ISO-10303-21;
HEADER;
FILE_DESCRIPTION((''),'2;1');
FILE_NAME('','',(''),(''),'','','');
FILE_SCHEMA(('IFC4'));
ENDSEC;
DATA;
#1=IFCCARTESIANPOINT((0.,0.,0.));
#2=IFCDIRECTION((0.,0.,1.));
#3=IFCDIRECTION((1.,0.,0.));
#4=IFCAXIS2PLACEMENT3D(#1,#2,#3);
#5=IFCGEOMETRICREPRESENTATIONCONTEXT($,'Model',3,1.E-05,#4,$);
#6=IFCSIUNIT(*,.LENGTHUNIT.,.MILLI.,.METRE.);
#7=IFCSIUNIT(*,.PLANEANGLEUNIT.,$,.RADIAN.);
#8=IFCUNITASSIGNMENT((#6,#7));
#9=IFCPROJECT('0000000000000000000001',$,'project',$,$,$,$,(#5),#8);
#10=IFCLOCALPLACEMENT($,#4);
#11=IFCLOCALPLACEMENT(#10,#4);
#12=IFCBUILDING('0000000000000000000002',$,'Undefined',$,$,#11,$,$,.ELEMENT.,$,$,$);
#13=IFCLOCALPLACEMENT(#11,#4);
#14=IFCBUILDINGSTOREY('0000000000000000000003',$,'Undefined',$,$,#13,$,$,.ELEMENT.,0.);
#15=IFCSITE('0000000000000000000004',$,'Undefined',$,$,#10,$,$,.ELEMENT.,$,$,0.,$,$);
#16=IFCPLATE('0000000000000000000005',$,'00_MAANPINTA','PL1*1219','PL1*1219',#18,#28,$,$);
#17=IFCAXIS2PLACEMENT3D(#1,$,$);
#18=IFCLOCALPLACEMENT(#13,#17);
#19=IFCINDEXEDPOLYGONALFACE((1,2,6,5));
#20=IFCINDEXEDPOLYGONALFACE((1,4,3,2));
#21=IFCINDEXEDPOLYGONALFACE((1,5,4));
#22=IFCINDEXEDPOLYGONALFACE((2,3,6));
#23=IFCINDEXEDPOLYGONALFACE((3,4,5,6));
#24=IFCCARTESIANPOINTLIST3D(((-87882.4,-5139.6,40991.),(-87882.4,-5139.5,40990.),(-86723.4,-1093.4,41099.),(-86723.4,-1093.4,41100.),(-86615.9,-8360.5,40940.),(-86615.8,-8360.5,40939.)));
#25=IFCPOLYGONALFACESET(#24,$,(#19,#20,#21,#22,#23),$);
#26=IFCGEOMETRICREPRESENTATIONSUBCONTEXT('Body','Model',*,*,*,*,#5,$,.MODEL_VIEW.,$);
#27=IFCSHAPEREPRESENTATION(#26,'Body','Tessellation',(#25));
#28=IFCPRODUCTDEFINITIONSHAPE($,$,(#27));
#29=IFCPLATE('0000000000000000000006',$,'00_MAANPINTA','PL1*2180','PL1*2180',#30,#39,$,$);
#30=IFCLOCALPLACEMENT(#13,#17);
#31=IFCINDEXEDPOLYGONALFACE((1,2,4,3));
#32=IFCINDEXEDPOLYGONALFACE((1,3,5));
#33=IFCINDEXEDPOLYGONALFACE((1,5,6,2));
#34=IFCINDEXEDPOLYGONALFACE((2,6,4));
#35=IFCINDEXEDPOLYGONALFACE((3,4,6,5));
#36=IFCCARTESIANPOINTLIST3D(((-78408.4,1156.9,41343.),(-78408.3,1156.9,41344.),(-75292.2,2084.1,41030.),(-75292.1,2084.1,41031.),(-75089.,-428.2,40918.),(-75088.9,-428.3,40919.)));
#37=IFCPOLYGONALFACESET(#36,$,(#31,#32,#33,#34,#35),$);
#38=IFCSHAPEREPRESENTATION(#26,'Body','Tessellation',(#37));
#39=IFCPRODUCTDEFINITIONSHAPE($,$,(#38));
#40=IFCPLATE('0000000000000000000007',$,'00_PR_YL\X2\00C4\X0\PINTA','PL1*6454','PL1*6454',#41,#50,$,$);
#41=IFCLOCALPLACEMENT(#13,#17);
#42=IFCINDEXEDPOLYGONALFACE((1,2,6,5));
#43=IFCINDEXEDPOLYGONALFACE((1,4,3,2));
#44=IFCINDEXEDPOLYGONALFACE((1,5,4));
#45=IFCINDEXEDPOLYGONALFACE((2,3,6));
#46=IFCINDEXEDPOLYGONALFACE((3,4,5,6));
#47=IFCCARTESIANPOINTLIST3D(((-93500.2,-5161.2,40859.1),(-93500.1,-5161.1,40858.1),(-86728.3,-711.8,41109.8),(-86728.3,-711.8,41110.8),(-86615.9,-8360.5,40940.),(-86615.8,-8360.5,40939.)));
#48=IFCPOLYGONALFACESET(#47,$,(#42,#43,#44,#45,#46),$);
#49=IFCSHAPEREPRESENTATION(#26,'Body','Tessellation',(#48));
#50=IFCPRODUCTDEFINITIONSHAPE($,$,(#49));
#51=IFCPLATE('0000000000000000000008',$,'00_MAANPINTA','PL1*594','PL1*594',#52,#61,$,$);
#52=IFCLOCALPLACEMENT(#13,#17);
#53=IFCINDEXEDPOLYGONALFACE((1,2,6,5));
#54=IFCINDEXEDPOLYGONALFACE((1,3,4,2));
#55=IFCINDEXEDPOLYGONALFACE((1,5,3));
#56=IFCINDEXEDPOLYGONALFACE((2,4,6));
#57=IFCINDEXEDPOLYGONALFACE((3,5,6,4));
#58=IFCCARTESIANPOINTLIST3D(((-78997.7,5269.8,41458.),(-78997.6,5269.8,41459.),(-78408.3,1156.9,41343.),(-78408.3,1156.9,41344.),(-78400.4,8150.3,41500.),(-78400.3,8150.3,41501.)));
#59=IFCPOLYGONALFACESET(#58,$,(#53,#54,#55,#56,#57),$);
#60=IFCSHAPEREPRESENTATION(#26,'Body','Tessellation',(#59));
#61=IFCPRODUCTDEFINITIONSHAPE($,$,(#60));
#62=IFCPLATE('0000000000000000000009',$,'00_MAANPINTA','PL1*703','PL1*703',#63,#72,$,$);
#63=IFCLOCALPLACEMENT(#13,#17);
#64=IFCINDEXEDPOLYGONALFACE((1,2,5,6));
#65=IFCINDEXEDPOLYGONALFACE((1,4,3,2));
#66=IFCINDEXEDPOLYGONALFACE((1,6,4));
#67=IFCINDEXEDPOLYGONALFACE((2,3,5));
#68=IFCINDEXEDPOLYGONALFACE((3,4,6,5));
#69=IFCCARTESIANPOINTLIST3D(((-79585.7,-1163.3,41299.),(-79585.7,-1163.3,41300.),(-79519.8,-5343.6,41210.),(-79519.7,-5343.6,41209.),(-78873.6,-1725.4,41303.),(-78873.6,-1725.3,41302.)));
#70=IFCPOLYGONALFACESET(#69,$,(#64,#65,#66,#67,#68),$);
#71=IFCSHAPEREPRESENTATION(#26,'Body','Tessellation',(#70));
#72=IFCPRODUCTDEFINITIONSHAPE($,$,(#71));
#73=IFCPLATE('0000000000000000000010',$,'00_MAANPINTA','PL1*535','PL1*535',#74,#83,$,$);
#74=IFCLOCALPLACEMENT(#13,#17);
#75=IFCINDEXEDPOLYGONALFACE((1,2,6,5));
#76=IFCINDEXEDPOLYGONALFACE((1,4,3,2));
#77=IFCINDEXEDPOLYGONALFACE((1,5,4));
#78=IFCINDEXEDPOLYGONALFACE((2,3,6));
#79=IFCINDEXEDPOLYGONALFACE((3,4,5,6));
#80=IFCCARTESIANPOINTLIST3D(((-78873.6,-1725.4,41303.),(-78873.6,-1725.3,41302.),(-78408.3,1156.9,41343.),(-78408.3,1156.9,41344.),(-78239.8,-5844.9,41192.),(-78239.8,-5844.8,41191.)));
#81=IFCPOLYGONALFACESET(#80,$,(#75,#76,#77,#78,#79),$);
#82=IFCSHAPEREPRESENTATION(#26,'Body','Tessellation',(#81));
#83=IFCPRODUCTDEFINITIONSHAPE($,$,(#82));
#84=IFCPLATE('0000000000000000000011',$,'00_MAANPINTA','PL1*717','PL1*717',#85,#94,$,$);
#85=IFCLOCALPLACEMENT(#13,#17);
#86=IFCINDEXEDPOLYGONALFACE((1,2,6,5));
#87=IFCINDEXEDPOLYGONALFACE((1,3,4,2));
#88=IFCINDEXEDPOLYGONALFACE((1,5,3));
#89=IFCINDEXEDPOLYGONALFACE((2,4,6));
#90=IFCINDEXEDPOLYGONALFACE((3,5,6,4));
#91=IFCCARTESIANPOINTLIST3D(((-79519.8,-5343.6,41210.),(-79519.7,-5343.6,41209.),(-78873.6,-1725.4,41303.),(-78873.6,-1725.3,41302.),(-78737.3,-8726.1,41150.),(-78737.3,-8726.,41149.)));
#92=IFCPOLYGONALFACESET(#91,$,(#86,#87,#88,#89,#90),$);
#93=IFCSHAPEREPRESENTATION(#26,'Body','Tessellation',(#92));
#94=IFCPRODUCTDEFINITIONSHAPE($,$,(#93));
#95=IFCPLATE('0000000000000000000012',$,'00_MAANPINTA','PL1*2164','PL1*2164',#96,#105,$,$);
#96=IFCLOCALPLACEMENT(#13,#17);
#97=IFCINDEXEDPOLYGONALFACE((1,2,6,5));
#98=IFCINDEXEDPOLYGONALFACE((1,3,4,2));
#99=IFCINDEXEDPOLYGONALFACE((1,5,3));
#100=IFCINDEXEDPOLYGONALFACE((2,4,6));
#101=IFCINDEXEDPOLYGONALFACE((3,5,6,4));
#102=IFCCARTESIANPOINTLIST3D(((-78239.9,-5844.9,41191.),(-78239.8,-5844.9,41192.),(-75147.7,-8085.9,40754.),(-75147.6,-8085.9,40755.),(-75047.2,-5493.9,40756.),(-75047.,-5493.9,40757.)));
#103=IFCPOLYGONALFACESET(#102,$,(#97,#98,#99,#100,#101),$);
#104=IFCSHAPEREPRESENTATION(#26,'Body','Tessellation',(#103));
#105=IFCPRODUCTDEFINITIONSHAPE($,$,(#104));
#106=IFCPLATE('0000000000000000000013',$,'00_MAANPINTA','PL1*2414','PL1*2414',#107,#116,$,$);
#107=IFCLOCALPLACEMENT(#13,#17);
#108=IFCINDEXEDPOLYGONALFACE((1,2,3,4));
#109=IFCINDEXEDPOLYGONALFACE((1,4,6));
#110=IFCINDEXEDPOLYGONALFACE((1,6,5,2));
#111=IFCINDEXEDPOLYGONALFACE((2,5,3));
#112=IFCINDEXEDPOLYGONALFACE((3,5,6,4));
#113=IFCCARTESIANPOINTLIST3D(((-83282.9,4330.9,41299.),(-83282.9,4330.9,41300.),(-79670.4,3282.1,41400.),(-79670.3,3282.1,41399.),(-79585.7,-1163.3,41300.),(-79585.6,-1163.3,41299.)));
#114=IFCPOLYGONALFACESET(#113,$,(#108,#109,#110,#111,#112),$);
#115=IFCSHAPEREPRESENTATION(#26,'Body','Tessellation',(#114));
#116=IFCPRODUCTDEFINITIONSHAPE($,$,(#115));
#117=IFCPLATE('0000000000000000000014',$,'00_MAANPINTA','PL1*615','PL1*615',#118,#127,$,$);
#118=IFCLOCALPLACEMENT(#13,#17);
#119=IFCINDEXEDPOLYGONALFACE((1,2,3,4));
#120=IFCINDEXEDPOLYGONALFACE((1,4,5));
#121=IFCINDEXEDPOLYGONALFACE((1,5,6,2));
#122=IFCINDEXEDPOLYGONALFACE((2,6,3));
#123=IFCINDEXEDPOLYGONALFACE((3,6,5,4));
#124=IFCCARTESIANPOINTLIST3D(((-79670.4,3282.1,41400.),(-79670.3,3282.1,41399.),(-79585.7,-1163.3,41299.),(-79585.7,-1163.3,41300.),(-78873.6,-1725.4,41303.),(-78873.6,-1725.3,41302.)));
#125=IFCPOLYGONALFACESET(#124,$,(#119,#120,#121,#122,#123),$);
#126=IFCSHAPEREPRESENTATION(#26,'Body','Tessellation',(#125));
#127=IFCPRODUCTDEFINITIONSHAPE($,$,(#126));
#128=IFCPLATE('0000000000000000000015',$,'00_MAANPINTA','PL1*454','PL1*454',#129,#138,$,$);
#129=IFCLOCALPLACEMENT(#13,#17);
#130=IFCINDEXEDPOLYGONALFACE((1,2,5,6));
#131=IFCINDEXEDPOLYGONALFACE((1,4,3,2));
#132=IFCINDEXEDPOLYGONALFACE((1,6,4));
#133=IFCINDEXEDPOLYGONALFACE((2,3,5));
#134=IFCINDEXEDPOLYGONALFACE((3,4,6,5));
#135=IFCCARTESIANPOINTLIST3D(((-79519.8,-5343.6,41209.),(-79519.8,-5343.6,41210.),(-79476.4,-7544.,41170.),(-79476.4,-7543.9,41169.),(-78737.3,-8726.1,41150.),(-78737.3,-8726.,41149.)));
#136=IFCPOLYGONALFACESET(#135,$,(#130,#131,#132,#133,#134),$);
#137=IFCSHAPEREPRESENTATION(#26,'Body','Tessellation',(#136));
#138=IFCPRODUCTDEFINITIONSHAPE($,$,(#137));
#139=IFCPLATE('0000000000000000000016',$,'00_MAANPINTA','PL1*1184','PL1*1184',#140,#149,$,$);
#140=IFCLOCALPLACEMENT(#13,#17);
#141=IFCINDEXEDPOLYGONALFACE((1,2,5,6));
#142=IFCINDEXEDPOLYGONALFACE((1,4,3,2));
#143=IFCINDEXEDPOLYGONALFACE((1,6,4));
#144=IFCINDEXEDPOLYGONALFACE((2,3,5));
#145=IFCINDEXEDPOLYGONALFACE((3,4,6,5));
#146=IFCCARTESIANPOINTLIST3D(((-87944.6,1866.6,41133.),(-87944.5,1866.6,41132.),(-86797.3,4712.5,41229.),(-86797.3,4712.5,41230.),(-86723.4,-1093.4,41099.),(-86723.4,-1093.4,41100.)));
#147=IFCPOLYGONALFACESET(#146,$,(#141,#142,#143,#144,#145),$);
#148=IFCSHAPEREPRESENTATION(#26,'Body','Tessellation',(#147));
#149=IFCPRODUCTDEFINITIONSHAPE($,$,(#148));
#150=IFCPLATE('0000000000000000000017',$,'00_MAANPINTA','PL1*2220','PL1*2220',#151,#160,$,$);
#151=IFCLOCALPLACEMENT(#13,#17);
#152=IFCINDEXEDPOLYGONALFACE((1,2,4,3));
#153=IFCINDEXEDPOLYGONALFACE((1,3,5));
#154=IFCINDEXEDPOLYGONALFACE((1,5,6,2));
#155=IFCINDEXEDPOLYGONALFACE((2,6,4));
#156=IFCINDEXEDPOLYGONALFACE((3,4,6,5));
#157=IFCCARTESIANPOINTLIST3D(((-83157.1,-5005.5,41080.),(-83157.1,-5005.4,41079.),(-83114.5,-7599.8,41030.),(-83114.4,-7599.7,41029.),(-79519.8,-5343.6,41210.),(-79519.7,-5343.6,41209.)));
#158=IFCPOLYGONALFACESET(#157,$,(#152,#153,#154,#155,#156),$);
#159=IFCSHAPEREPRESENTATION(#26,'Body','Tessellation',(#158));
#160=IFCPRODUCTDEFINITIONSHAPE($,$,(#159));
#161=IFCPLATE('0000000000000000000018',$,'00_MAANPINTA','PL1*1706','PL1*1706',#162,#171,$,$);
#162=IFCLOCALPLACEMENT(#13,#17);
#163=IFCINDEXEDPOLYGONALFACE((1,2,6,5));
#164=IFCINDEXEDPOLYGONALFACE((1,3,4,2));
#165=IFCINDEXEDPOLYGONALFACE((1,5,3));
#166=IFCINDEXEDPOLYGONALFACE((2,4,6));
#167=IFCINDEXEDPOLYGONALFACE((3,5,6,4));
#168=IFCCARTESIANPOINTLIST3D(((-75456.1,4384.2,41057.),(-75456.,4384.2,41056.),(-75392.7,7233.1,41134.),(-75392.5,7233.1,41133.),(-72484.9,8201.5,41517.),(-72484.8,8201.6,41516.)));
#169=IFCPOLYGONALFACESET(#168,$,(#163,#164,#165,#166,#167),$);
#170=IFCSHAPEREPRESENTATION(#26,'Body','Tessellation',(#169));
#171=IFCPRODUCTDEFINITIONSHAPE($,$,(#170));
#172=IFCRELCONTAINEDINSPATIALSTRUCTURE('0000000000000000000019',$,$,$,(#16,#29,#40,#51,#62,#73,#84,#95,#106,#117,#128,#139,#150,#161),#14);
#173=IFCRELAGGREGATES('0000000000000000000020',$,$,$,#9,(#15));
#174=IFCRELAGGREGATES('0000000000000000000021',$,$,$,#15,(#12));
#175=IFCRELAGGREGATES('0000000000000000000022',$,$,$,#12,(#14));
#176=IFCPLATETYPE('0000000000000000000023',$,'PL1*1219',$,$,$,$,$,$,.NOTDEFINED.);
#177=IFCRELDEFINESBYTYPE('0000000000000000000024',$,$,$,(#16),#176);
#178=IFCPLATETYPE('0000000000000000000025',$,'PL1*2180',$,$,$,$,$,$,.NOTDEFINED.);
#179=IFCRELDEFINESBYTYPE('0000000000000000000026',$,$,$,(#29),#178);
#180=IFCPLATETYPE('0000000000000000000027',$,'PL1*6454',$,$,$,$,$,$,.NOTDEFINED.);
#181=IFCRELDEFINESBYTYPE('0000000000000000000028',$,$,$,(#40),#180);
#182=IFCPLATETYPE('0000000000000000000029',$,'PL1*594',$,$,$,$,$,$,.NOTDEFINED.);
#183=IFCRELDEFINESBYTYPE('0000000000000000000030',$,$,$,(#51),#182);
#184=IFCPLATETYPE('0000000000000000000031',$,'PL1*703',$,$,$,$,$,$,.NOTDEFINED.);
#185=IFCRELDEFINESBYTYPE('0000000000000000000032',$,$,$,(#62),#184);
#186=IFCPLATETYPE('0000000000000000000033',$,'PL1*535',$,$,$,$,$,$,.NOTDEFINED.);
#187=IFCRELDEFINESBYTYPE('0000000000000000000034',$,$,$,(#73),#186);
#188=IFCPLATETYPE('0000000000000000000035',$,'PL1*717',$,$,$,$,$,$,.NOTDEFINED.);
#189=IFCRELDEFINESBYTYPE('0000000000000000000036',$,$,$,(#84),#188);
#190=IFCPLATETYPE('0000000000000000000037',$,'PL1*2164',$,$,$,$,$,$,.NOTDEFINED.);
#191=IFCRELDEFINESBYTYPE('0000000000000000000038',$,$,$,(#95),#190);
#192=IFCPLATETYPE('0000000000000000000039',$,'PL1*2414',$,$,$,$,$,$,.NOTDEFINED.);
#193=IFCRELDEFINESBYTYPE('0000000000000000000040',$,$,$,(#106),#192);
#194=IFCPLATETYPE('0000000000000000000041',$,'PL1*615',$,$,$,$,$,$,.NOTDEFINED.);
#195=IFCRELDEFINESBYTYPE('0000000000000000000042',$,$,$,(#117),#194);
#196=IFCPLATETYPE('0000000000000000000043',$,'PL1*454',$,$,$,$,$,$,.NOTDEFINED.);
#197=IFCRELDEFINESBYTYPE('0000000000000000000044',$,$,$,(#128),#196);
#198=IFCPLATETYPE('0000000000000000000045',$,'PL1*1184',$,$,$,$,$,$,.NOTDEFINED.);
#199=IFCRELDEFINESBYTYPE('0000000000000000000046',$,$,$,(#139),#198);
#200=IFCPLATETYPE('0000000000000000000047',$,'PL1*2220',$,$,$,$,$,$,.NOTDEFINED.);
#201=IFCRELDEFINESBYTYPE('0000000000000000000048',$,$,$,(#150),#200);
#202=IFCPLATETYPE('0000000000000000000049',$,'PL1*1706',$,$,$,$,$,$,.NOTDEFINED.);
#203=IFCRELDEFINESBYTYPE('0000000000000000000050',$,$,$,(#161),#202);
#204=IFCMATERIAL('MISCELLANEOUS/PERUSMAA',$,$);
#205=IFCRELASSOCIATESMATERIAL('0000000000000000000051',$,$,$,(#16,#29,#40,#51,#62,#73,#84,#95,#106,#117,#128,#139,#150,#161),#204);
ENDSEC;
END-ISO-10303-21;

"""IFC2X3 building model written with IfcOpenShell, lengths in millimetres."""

from ifc_helpers import new_model, si_unit, frame, origin_with_axes, place, context, subcontext, project, spatial, polyline, outline, extrude, material, type_object, element, save


model = new_model("IFC2X3")

# Units and contexts
model_context = context("Model", 3, precision=1e-05, world=origin_with_axes())
body_context = subcontext(model_context, "Body", "Model", "MODEL_VIEW")
ifc_project = project(units=[si_unit("LENGTHUNIT", "METRE", prefix="MILLI"), si_unit("PLANEANGLEUNIT", "RADIAN")], contexts=[model_context])

# Site, building, storey
site_placement = place(None, origin_with_axes())
site = spatial("IfcSite", under=ifc_project, at=site_placement, Name="Undefined", CompositionType="ELEMENT", RefElevation=0.0)
building_placement = place(site_placement, origin_with_axes())
building = spatial("IfcBuilding", under=site, at=building_placement, Name="Undefined", CompositionType="ELEMENT")
storey_placement = place(building_placement, origin_with_axes())
storey = spatial("IfcBuildingStorey", under=building, at=storey_placement, Name="Undefined", CompositionType="ELEMENT", Elevation=0.0)

# Plates
ifc_material = material(Name="MISCELLANEOUS/PERUSMAA")
plate_type_1 = type_object("IfcPlateType", Name="PL1*1219", PredefinedType="NOTDEFINED")
plate_1_placement = place(storey_placement, frame((-86615.9, -8360.5, 40939.5), z_axis=(0.016334, 0.022251, -0.999619), x_axis=(-0.3659, 0.930537, 0.014734)))
element("IfcPlate", 1, at=plate_1_placement, inside=storey, type_object=plate_type_1, material=ifc_material, Name="00_MAANPINTA", Description="PL1*1219", ObjectType="PL1*1219", context=body_context, shape_type="SweptSolid", body=[
    extrude(outline(polyline([(0.0, 0.0), (3461.4, 0.0), (6804.0, 2559.9), (0.0, 0.0)])), frame((0.0, 0.0, -0.5), z_axis=(0.0, 0.0, 1.0), x_axis=(1.0, 0.0, 0.0)), (0.0, 0.0, 1.0), 1.0),
])
plate_type_2 = type_object("IfcPlateType", Name="PL1*2180", PredefinedType="NOTDEFINED")
plate_2_placement = place(storey_placement, frame((-78408.3, 1156.9, 41343.5), z_axis=(-0.110288, 0.035359, -0.993271), x_axis=(0.954062, 0.283871, -0.095829)))
element("IfcPlate", 2, at=plate_2_placement, inside=storey, type_object=plate_type_2, material=ifc_material, Name="00_MAANPINTA", Description="PL1*2180", ObjectType="PL1*2180", context=body_context, shape_type="SweptSolid", body=[
    extrude(outline(polyline([(0.0, 0.0), (3266.2, 0.0), (2757.7, 2471.3), (0.0, 0.0)])), frame((0.0, 0.0, -0.5), z_axis=(0.0, 0.0, 1.0), x_axis=(1.0, 0.0, 0.0)), (0.0, 0.0, 1.0), 1.0),
])
plate_type_3 = type_object("IfcPlateType", Name="PL1*6454", PredefinedType="NOTDEFINED")
plate_3_placement = place(storey_placement, frame((-86728.3, -711.8, 41110.3), z_axis=(0.022274, 0.022651, -0.999495), x_axis=(0.014694, -0.999643, -0.022327)))
element("IfcPlate", 3, at=plate_3_placement, inside=storey, type_object=plate_type_3, material=ifc_material, Name="00_PR_YLÄPINTA", Description="PL1*6454", ObjectType="PL1*6454", context=body_context, shape_type="SweptSolid", body=[
    extrude(outline(polyline([(0.0, 0.0), (7651.4, 0.0), (4353.9, 6838.3), (0.0, 0.0)])), frame((0.0, 0.0, -0.5), z_axis=(0.0, 0.0, 1.0), x_axis=(1.0, 0.0, 0.0)), (0.0, 0.0, 1.0), 1.0),
])
plate_type_4 = type_object("IfcPlateType", Name="PL1*594", PredefinedType="NOTDEFINED")
plate_4_placement = place(storey_placement, frame((-78408.3, 1156.9, 41343.5), z_axis=(-0.038119, 0.022471, -0.99902), x_axis=(-0.141791, 0.98951, 0.027667)))
element("IfcPlate", 4, at=plate_4_placement, inside=storey, type_object=plate_type_4, material=ifc_material, Name="00_MAANPINTA", Description="PL1*594", ObjectType="PL1*594", context=body_context, shape_type="SweptSolid", body=[
    extrude(outline(polyline([(0.0, 0.0), (4156.5, 0.0), (6923.3, 1000.4), (0.0, 0.0)])), frame((0.0, 0.0, -0.5), z_axis=(0.0, 0.0, 1.0), x_axis=(1.0, 0.0, 0.0)), (0.0, 0.0, 1.0), 1.0),
])
plate_type_5 = type_object("IfcPlateType", Name="PL1*703", PredefinedType="NOTDEFINED")
plate_5_placement = place(storey_placement, frame((-79519.8, -5343.6, 41209.5), z_axis=(0.021464, 0.021858, -0.999531), x_axis=(-0.015762, 0.999644, 0.021522)))
element("IfcPlate", 5, at=plate_5_placement, inside=storey, type_object=plate_type_5, material=ifc_material, Name="00_MAANPINTA", Description="PL1*703", ObjectType="PL1*703", context=body_context, shape_type="SweptSolid", body=[
    extrude(outline(polyline([(0.0, 0.0), (4181.8, 0.0), (3608.8, 703.3), (0.0, 0.0)])), frame((0.0, 0.0, -0.5), z_axis=(0.0, 0.0, 1.0), x_axis=(1.0, 0.0, 0.0)), (0.0, 0.0, 1.0), 1.0),
])
plate_type_6 = type_object("IfcPlateType", Name="PL1*535", PredefinedType="NOTDEFINED")
plate_6_placement = place(storey_placement, frame((-78239.8, -5844.9, 41191.5), z_axis=(-0.040302, 0.020717, -0.998973), x_axis=(-0.152014, 0.98802, 0.026622)))
element("IfcPlate", 6, at=plate_6_placement, inside=storey, type_object=plate_type_6, material=ifc_material, Name="00_MAANPINTA", Description="PL1*535", ObjectType="PL1*535", context=body_context, shape_type="SweptSolid", body=[
    extrude(outline(polyline([(0.0, 0.0), (4169.4, 0.0), (6947.5, 898.8), (0.0, 0.0)])), frame((0.0, 0.0, -0.5), z_axis=(0.0, 0.0, 1.0), x_axis=(1.0, 0.0, 0.0)), (0.0, 0.0, 1.0), 1.0),
])
plate_type_7 = type_object("IfcPlateType", Name="PL1*717", PredefinedType="NOTDEFINED")
plate_7_placement = place(storey_placement, frame((-78873.6, -1725.4, 41302.5), z_axis=(0.019421, 0.022224, -0.999564), x_axis=(0.019465, -0.999572, -0.021846)))
element("IfcPlate", 7, at=plate_7_placement, inside=storey, type_object=plate_type_7, material=ifc_material, Name="00_MAANPINTA", Description="PL1*717", ObjectType="PL1*717", context=body_context, shape_type="SweptSolid", body=[
    extrude(outline(polyline([(0.0, 0.0), (7003.7, 0.0), (3606.1, 716.6), (0.0, 0.0)])), frame((0.0, 0.0, -0.5), z_axis=(0.0, 0.0, 1.0), x_axis=(1.0, 0.0, 0.0)), (0.0, 0.0, 1.0), 1.0),
])
plate_type_8 = type_object("IfcPlateType", Name="PL1*2164", PredefinedType="NOTDEFINED")
plate_8_placement = place(storey_placement, frame((-78239.9, -5844.9, 41191.5), z_axis=(-0.135647, 0.006026, -0.990739), x_axis=(0.985021, 0.108269, -0.134206)))
element("IfcPlate", 8, at=plate_8_placement, inside=storey, type_object=plate_type_8, material=ifc_material, Name="00_MAANPINTA", Description="PL1*2164", ObjectType="PL1*2164", context=body_context, shape_type="SweptSolid", body=[
    extrude(outline(polyline([(0.0, 0.0), (3241.3, 0.0), (2861.9, 2566.0), (0.0, 0.0)])), frame((0.0, 0.0, -0.5), z_axis=(0.0, 0.0, 1.0), x_axis=(1.0, 0.0, 0.0)), (0.0, 0.0, 1.0), 1.0),
])
plate_type_9 = type_object("IfcPlateType", Name="PL1*2414", PredefinedType="NOTDEFINED")
plate_9_placement = place(storey_placement, frame((-83282.9, 4330.9, 41299.5), z_axis=(0.034373, 0.023131, -0.999141), x_axis=(0.960005, -0.278718, 0.026574)))
element("IfcPlate", 9, at=plate_9_placement, inside=storey, type_object=plate_type_9, material=ifc_material, Name="00_MAANPINTA", Description="PL1*2414", ObjectType="PL1*2414", context=body_context, shape_type="SweptSolid", body=[
    extrude(outline(polyline([(0.0, 0.0), (3763.1, 0.0), (5080.7, 4247.6), (0.0, 0.0)])), frame((0.0, 0.0, -0.5), z_axis=(0.0, 0.0, 1.0), x_axis=(1.0, 0.0, 0.0)), (0.0, 0.0, 1.0), 1.0),
])
plate_type_10 = type_object("IfcPlateType", Name="PL1*615", PredefinedType="NOTDEFINED")
plate_10_placement = place(storey_placement, frame((-79670.3, 3282.1, 41399.5), z_axis=(0.022294, 0.022909, -0.999489), x_axis=(0.15711, -0.987396, -0.019127)))
element("IfcPlate", 10, at=plate_10_placement, inside=storey, type_object=plate_type_10, material=ifc_material, Name="00_MAANPINTA", Description="PL1*615", ObjectType="PL1*615", context=body_context, shape_type="SweptSolid", body=[
    extrude(outline(polyline([(0.0, 0.0), (5071.4, 0.0), (4404.5, 615.1), (0.0, 0.0)])), frame((0.0, 0.0, -0.5), z_axis=(0.0, 0.0, 1.0), x_axis=(1.0, 0.0, 0.0)), (0.0, 0.0, 1.0), 1.0),
])
plate_type_11 = type_object("IfcPlateType", Name="PL1*454", PredefinedType="NOTDEFINED")
plate_11_placement = place(storey_placement, frame((-79519.8, -5343.6, 41209.5), z_axis=(0.00208, 0.018217, -0.999832), x_axis=(0.225352, -0.974124, -0.01728)))
element("IfcPlate", 11, at=plate_11_placement, inside=storey, type_object=plate_type_11, material=ifc_material, Name="00_MAANPINTA", Description="PL1*454", ObjectType="PL1*454", context=body_context, shape_type="SweptSolid", body=[
    extrude(outline(polyline([(0.0, 0.0), (3472.3, 0.0), (2153.9, 453.7), (0.0, 0.0)])), frame((0.0, 0.0, -0.5), z_axis=(0.0, 0.0, 1.0), x_axis=(1.0, 0.0, 0.0)), (0.0, 0.0, 1.0), 1.0),
])
plate_type_12 = type_object("IfcPlateType", Name="PL1*1184", PredefinedType="NOTDEFINED")
plate_12_placement = place(storey_placement, frame((-86723.4, -1093.4, 41099.5), z_axis=(0.0281, 0.022734, -0.999347), x_axis=(-0.381346, 0.924375, 0.010306)))
element("IfcPlate", 12, at=plate_12_placement, inside=storey, type_object=plate_type_12, material=ifc_material, Name="00_MAANPINTA", Description="PL1*1184", ObjectType="PL1*1184", context=body_context, shape_type="SweptSolid", body=[
    extrude(outline(polyline([(0.0, 0.0), (3202.2, 0.0), (5396.4, 2147.2), (0.0, 0.0)])), frame((0.0, 0.0, -0.5), z_axis=(0.0, 0.0, 1.0), x_axis=(1.0, 0.0, 0.0)), (0.0, 0.0, 1.0), 1.0),
])
plate_type_13 = type_object("IfcPlateType", Name="PL1*2220", PredefinedType="NOTDEFINED")
plate_13_placement = place(storey_placement, frame((-83114.4, -7599.8, 41029.5), z_axis=(0.037556, 0.019873, -0.999097), x_axis=(-0.016426, 0.999679, 0.019267)))
element("IfcPlate", 13, at=plate_13_placement, inside=storey, type_object=plate_type_13, material=ifc_material, Name="00_MAANPINTA", Description="PL1*2220", ObjectType="PL1*2220", context=body_context, shape_type="SweptSolid", body=[
    extrude(outline(polyline([(0.0, 0.0), (2595.1, 0.0), (2199.9, 3633.9), (0.0, 0.0)])), frame((0.0, 0.0, -0.5), z_axis=(0.0, 0.0, 1.0), x_axis=(1.0, 0.0, 0.0)), (0.0, 0.0, 1.0), 1.0),
])
plate_type_14 = type_object("IfcPlateType", Name="PL1*1706", PredefinedType="NOTDEFINED")
plate_14_placement = place(storey_placement, frame((-75456.1, 4384.2, 41056.5), z_axis=(0.122664, 0.024083, -0.992156), x_axis=(0.022264, 0.999387, 0.027011)))
element("IfcPlate", 14, at=plate_14_placement, inside=storey, type_object=plate_type_14, material=ifc_material, Name="00_MAANPINTA", Description="PL1*1706", ObjectType="PL1*1706", context=body_context, shape_type="SweptSolid", body=[
    extrude(outline(polyline([(0.0, 0.0), (2850.7, 0.0), (3893.6, 2907.2), (0.0, 0.0)])), frame((0.0, 0.0, -0.5), z_axis=(0.0, 0.0, 1.0), x_axis=(1.0, 0.0, 0.0)), (0.0, 0.0, 1.0), 1.0),
])

save(model, "model.ifc")
